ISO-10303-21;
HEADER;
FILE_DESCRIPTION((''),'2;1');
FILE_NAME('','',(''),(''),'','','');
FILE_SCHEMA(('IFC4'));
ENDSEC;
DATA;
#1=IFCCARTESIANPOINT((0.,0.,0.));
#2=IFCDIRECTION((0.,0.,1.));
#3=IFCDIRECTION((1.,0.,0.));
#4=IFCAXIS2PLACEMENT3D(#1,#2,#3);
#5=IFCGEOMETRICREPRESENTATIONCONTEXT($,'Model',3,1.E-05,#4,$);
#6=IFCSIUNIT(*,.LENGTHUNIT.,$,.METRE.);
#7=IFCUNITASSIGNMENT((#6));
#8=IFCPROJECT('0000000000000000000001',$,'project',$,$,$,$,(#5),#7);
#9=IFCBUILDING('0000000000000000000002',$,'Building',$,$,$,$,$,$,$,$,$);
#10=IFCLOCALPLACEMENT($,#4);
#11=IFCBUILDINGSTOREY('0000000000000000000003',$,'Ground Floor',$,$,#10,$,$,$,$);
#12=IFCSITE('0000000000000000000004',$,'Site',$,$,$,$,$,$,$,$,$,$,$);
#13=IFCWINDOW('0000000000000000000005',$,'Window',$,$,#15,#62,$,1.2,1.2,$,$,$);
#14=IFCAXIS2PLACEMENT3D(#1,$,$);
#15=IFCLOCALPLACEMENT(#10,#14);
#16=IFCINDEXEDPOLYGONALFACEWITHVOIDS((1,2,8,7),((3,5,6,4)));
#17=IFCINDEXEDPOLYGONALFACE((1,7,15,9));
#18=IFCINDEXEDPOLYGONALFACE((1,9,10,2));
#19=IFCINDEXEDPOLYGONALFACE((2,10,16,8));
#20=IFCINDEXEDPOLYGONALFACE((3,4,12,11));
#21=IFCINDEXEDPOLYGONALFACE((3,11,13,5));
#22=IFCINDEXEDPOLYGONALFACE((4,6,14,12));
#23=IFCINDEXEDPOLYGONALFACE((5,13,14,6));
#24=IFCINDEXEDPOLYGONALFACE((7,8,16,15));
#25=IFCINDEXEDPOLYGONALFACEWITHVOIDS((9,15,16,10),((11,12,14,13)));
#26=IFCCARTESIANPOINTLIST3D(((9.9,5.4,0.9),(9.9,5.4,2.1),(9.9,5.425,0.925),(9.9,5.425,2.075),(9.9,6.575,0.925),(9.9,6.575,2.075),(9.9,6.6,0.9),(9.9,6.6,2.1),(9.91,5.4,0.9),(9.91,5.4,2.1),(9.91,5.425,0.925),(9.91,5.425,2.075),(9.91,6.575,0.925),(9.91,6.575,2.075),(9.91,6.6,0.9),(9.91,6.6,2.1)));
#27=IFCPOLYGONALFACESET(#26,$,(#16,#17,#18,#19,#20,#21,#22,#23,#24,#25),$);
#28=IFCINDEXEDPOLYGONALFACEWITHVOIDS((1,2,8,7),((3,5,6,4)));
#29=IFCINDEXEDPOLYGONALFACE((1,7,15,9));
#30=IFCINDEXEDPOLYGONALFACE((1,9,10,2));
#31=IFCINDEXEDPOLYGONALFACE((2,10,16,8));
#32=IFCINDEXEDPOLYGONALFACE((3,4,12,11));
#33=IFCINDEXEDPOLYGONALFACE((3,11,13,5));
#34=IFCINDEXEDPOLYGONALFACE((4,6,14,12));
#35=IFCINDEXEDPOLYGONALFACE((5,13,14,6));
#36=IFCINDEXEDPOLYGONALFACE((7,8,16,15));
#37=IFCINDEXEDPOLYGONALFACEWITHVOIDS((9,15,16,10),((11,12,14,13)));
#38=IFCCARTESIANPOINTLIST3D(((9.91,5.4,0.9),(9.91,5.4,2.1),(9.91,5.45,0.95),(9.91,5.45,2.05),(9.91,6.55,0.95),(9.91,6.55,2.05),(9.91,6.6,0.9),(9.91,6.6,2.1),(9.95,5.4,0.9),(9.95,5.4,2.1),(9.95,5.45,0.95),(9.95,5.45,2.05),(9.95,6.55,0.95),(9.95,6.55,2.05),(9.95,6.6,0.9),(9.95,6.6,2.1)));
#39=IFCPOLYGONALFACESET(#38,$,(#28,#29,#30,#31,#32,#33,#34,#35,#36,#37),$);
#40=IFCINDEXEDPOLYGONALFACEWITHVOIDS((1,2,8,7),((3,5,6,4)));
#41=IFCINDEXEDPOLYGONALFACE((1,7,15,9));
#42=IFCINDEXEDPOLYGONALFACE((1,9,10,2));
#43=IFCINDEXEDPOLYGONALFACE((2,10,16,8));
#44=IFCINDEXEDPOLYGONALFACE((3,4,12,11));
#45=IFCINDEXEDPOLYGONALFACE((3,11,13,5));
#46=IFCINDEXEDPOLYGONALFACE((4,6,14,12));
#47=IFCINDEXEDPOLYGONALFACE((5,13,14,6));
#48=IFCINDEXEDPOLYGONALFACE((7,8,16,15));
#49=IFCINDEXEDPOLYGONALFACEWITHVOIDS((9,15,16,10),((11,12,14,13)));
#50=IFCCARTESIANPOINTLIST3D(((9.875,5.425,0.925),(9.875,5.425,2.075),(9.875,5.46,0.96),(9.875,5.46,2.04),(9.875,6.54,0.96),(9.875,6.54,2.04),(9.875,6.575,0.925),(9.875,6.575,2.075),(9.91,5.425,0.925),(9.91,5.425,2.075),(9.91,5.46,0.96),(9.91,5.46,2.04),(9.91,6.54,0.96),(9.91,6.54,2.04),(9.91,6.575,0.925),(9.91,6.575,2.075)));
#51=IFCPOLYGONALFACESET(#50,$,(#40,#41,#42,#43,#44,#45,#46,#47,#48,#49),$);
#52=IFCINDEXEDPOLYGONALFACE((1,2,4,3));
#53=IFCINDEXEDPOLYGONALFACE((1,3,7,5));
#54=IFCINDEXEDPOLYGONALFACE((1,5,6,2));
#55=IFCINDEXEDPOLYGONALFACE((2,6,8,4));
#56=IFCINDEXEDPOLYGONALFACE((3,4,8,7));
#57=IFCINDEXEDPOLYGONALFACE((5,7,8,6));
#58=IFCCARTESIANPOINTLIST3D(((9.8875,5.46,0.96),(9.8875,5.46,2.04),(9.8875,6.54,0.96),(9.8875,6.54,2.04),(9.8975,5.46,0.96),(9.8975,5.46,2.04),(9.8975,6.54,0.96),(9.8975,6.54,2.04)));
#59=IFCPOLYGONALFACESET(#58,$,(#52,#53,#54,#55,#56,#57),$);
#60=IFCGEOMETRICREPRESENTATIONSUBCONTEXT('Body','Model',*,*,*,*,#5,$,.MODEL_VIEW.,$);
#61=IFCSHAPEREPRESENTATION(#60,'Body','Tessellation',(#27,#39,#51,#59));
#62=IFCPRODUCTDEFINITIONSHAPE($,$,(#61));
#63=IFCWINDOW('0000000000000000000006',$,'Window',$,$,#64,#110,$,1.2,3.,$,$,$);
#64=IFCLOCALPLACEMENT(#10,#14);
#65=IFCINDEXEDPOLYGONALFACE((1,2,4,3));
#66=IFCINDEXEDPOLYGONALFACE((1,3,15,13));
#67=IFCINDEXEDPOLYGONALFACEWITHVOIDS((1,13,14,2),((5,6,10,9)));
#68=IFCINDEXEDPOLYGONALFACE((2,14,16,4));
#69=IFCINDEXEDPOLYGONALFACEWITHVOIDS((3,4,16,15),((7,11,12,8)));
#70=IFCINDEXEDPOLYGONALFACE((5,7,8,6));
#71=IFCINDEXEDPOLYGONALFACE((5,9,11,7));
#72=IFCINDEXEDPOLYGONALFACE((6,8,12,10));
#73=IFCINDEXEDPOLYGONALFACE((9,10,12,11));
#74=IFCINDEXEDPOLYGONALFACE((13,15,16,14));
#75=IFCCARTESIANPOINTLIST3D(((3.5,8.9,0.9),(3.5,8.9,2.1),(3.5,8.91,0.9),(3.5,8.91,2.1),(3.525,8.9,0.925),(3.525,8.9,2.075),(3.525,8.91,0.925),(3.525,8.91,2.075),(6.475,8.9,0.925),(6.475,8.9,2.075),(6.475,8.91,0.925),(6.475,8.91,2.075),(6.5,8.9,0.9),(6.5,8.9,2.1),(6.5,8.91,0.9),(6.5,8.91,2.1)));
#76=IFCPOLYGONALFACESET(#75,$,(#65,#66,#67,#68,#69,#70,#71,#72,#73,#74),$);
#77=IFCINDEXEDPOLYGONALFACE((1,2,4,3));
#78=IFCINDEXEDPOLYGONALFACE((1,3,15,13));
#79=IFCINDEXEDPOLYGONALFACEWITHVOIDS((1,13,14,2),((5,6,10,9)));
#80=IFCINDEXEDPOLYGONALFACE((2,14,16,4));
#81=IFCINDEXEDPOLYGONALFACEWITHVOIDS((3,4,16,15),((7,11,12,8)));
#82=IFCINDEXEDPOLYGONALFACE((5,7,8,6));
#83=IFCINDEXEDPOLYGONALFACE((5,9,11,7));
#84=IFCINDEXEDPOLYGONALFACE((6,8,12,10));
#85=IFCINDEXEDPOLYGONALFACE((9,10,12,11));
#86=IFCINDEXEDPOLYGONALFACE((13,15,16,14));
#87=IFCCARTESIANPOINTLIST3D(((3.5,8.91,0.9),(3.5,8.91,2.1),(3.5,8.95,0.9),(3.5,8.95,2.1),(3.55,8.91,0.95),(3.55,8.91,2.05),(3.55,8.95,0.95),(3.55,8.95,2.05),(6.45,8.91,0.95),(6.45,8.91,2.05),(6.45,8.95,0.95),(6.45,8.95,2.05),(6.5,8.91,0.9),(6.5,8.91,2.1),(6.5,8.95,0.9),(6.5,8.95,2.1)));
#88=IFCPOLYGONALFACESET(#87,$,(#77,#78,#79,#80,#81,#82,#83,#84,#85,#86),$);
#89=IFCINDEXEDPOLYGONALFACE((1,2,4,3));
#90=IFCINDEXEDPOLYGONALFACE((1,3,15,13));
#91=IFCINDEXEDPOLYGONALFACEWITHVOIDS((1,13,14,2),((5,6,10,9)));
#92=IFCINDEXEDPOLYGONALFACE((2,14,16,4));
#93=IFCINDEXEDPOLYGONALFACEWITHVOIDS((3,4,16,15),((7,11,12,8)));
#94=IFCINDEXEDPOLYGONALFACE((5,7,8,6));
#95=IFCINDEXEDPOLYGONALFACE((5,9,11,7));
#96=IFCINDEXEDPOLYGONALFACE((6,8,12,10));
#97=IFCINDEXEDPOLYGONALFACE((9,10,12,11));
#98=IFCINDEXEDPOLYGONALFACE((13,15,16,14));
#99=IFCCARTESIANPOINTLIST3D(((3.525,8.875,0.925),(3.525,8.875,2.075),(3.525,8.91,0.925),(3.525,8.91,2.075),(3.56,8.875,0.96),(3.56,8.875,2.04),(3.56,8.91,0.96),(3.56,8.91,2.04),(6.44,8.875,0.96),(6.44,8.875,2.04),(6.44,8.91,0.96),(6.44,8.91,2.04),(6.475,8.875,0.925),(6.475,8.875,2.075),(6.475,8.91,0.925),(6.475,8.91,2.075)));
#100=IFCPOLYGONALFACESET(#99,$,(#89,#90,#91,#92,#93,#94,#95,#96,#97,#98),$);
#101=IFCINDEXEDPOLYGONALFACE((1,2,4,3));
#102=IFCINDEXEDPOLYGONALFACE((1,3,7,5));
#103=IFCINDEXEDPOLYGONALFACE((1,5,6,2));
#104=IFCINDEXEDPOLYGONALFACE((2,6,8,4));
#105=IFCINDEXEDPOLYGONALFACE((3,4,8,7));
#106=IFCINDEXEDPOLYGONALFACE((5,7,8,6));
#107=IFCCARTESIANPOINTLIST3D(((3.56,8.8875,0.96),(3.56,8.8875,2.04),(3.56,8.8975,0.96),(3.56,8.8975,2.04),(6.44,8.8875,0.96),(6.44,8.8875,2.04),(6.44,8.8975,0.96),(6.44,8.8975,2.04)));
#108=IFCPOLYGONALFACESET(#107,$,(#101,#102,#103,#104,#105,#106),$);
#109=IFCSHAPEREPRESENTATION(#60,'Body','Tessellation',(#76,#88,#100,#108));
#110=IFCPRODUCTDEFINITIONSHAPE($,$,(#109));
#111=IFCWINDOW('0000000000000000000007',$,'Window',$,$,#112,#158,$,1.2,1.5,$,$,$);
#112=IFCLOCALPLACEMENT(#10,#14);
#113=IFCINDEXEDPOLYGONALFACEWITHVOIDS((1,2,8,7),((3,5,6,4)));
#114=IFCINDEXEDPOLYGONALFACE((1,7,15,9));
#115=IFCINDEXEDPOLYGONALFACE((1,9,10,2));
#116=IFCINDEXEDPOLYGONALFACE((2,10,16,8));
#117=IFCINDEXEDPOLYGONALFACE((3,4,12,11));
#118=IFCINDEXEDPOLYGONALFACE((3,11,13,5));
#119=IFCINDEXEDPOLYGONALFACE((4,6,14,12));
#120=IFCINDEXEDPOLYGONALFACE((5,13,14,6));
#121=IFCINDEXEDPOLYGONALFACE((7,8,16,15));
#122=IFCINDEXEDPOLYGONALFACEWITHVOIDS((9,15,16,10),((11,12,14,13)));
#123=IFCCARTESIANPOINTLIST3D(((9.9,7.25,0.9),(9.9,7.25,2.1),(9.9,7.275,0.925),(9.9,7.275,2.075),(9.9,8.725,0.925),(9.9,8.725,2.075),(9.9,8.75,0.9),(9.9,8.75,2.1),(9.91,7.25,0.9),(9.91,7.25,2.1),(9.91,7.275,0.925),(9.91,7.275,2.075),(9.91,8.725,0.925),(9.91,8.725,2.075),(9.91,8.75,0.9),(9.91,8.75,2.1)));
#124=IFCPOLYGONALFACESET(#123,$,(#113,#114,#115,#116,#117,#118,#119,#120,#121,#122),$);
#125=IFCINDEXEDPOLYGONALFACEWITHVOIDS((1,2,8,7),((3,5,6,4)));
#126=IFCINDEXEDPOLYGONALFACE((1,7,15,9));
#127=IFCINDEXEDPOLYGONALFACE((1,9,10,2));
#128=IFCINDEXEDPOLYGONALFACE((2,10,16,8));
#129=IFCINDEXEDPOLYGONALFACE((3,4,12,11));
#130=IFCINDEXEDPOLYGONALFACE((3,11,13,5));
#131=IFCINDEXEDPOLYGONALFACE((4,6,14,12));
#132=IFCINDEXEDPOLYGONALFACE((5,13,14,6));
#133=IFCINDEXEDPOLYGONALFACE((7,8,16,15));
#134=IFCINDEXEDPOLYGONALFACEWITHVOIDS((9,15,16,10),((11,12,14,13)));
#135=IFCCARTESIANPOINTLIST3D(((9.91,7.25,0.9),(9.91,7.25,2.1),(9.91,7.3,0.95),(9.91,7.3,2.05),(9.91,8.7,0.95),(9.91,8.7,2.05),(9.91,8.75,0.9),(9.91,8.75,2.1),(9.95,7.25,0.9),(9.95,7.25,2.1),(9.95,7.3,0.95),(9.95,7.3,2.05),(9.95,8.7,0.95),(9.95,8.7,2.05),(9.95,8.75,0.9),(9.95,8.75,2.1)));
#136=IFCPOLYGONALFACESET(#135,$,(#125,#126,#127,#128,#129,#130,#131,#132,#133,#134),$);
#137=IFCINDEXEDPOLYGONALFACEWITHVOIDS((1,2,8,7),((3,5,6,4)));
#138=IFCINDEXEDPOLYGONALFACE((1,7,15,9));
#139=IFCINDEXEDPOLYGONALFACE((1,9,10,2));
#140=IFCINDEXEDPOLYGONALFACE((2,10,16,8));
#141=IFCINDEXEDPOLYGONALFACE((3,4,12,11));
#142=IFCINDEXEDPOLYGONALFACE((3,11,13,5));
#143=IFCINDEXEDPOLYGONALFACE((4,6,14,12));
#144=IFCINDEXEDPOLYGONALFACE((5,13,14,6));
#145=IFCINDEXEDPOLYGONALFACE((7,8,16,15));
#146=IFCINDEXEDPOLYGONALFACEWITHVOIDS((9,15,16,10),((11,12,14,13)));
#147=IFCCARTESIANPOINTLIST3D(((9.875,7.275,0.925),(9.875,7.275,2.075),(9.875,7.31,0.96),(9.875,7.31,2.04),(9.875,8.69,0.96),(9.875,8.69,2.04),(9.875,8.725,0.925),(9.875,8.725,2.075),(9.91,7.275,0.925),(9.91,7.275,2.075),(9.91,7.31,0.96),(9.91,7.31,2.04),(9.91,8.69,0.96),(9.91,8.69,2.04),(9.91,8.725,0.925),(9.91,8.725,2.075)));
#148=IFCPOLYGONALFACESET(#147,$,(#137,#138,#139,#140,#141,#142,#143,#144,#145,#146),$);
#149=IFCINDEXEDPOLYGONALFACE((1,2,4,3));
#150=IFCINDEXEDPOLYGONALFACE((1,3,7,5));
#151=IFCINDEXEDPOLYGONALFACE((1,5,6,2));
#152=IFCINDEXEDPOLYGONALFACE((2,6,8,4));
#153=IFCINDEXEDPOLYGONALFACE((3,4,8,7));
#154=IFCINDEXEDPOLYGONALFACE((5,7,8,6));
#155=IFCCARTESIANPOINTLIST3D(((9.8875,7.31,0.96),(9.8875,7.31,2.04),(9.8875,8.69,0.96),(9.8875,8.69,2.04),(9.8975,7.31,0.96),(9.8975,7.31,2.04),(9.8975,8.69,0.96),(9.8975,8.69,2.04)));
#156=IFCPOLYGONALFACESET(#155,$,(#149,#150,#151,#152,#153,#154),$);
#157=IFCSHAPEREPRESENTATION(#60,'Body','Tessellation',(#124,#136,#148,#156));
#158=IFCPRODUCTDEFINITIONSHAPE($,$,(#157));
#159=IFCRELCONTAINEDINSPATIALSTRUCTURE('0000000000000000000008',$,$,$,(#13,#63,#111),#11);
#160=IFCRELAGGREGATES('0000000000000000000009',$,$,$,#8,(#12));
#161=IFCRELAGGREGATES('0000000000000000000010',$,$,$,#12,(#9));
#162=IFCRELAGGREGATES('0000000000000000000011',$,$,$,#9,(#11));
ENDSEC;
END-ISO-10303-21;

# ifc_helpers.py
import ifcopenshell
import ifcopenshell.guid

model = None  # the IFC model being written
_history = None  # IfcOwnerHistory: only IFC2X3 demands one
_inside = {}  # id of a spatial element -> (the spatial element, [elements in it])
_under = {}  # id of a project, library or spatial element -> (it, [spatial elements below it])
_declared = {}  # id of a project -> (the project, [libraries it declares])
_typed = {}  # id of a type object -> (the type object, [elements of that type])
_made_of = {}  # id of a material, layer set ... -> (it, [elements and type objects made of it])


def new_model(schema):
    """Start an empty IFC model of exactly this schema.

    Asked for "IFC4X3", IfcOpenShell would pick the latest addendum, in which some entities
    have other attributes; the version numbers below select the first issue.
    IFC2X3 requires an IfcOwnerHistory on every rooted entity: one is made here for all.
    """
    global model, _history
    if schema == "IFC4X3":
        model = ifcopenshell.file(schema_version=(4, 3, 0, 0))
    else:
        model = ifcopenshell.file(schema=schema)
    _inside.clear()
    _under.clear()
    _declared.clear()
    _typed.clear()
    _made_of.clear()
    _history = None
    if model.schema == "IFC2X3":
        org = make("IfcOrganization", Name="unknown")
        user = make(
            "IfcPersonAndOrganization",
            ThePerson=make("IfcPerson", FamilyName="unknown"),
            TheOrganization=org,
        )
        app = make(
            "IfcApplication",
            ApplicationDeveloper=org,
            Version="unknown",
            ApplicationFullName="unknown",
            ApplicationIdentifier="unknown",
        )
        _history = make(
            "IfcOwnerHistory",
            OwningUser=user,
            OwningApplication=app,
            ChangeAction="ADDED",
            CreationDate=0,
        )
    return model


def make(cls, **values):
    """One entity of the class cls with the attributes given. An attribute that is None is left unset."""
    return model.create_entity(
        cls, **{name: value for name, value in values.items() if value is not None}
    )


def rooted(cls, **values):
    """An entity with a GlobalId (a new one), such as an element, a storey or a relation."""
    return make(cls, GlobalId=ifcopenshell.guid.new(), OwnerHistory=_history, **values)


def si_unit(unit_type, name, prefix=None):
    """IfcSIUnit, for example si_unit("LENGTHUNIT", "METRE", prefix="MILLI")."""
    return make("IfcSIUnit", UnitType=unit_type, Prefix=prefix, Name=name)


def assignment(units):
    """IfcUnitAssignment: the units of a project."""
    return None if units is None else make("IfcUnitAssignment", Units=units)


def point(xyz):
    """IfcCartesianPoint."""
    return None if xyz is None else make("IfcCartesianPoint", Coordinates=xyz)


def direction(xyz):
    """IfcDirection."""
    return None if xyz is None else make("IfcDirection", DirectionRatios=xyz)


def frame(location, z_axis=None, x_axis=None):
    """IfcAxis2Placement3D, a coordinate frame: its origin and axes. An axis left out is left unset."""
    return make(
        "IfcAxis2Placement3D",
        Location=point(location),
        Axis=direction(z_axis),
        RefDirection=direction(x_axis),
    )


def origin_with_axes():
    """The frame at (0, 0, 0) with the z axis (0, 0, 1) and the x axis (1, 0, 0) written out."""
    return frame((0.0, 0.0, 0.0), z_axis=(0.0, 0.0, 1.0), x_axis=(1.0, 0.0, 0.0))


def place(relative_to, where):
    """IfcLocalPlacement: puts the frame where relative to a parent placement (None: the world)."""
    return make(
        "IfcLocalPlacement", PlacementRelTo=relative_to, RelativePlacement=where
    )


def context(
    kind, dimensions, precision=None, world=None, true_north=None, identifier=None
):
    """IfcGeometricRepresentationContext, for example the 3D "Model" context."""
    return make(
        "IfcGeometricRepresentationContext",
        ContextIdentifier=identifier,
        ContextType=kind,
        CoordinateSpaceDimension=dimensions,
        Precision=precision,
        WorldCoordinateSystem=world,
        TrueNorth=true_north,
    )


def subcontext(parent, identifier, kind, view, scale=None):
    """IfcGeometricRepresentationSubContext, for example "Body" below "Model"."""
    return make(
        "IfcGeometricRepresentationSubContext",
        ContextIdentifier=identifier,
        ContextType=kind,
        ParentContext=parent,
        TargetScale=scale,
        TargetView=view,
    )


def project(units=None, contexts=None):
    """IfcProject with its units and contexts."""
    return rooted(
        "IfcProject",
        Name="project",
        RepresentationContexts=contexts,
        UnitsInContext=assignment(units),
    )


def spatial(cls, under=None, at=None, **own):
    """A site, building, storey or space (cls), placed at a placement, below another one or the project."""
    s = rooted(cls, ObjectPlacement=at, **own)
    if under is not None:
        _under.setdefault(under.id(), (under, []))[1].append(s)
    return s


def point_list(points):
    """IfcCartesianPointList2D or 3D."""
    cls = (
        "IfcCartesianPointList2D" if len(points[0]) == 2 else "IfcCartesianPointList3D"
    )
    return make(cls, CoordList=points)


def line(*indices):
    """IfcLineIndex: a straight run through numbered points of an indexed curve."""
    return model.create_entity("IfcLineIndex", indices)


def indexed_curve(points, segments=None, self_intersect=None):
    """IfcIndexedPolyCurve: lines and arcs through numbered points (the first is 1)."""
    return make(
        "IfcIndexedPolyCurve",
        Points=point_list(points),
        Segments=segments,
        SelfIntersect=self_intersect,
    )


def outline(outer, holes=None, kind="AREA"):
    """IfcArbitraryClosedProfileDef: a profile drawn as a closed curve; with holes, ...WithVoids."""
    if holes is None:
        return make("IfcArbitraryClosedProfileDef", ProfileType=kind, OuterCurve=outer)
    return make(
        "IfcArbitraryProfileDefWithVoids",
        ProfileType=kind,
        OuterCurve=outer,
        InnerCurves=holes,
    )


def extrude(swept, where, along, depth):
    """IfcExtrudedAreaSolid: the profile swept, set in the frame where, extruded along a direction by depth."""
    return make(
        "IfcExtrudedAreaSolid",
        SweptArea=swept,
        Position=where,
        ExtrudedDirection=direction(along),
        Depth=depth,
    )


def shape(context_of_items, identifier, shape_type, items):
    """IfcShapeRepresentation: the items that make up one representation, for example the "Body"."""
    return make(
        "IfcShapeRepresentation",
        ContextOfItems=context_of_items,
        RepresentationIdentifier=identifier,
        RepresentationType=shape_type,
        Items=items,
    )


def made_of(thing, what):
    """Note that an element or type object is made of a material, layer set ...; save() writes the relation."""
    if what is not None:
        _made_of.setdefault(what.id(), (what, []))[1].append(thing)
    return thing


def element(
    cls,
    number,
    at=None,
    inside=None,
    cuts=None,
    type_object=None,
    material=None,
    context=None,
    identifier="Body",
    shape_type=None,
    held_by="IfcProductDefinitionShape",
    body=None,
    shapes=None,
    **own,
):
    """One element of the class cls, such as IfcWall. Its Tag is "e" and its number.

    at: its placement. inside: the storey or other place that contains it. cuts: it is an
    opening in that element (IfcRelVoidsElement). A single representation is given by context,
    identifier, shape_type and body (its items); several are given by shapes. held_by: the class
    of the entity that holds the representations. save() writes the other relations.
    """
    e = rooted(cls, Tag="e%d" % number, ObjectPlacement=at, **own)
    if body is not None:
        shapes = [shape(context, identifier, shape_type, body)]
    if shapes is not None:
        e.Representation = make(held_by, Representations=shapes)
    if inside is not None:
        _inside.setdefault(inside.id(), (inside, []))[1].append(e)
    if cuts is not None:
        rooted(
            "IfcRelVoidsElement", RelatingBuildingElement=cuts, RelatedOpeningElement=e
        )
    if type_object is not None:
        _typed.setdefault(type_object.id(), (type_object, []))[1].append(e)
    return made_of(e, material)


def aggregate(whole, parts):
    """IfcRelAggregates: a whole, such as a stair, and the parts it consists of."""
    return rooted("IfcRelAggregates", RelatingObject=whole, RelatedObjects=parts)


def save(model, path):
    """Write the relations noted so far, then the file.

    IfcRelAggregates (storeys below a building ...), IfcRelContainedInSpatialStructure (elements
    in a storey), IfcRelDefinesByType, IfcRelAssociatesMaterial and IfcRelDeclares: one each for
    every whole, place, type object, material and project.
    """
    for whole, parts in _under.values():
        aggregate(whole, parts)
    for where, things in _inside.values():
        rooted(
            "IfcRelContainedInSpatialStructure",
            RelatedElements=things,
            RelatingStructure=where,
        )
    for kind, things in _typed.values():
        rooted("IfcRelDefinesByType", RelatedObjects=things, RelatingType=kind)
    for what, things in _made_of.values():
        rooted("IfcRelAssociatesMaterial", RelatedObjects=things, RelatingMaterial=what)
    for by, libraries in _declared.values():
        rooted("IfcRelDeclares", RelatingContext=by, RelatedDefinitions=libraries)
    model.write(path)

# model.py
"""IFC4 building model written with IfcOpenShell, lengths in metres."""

from ifc_helpers import new_model, si_unit, frame, origin_with_axes, place, context, subcontext, project, spatial, line, indexed_curve, outline, extrude, element, save


model = new_model("IFC4")

# Units and contexts
model_context = context("Model", 3, precision=1e-05, world=origin_with_axes())
body_context = subcontext(model_context, "Body", "Model", "MODEL_VIEW")
ifc_project = project(units=[si_unit("LENGTHUNIT", "METRE")], contexts=[model_context])

# Site, building, storey
site = spatial("IfcSite", under=ifc_project, Name="Site")
building = spatial("IfcBuilding", under=site, Name="Building")
storey_placement = place(None, origin_with_axes())
storey = spatial("IfcBuildingStorey", under=building, at=storey_placement, Name="Ground Floor")

# Windows
window_1_placement = place(storey_placement, frame((10.0, 5.4, 0.9), z_axis=(0.0, 0.0, 1.0), x_axis=(0.0, 1.0, 0.0)))
element("IfcWindow", 1, at=window_1_placement, inside=storey, Name="Window", OverallHeight=1.2, OverallWidth=1.2, context=body_context, shape_type="SweptSolid", body=[
    extrude(outline(indexed_curve([(0.0, 0.0), (1.2, 0.0), (1.2, 1.2), (0.0, 1.2)], segments=[line(1, 2, 3, 4, 1)]), holes=[indexed_curve([(0.025, 0.025), (1.175, 0.025), (1.175, 1.175), (0.025, 1.175)], segments=[line(1, 2, 3, 4, 1)])]), frame((0.0, 0.09, 0.0), z_axis=(0.0, -1.0, 0.0), x_axis=(1.0, 0.0, 0.0)), (0.0, 0.0, -1.0), 0.01),
    extrude(outline(indexed_curve([(0.0, 0.0), (1.2, 0.0), (1.2, 1.2), (0.0, 1.2)], segments=[line(1, 2, 3, 4, 1)]), holes=[indexed_curve([(0.05, 0.05), (1.15, 0.05), (1.15, 1.15), (0.05, 1.15)], segments=[line(1, 2, 3, 4, 1)])]), frame((0.0, 0.05, 0.0), z_axis=(0.0, -1.0, 0.0), x_axis=(1.0, 0.0, 0.0)), (0.0, 0.0, -1.0), 0.04),
    extrude(outline(indexed_curve([(0.0, 0.0), (1.15, 0.0), (1.15, 1.15), (0.0, 1.15)], segments=[line(1, 2, 3, 4, 1)]), holes=[indexed_curve([(0.035, 0.035), (1.115, 0.035), (1.115, 1.115), (0.035, 1.115)], segments=[line(1, 2, 3, 4, 1)])]), frame((0.025, 0.09, 0.025), z_axis=(0.0, -1.0, 0.0), x_axis=(1.0, 0.0, 0.0)), (0.0, 0.0, -1.0), 0.035),
    extrude(outline(indexed_curve([(0.035, 0.035), (1.115, 0.035), (1.115, 1.115), (0.035, 1.115)], segments=[line(1, 2, 3, 4, 1)])), frame((0.025, 0.1025, 0.025), z_axis=(0.0, -1.0, 0.0), x_axis=(1.0, 0.0, 0.0)), (0.0, 0.0, -1.0), 0.01),
])
window_2_placement = place(storey_placement, frame((6.5, 9.0, 0.9), z_axis=(0.0, 0.0, 1.0), x_axis=(-1.0, 0.0, 0.0)))
element("IfcWindow", 2, at=window_2_placement, inside=storey, Name="Window", OverallHeight=1.2, OverallWidth=3.0, context=body_context, shape_type="SweptSolid", body=[
    extrude(outline(indexed_curve([(0.0, 0.0), (3.0, 0.0), (3.0, 1.2), (0.0, 1.2)], segments=[line(1, 2, 3, 4, 1)]), holes=[indexed_curve([(0.025, 0.025), (2.975, 0.025), (2.975, 1.175), (0.025, 1.175)], segments=[line(1, 2, 3, 4, 1)])]), frame((0.0, 0.09, 0.0), z_axis=(0.0, -1.0, 0.0), x_axis=(1.0, 0.0, 0.0)), (0.0, 0.0, -1.0), 0.01),
    extrude(outline(indexed_curve([(0.0, 0.0), (3.0, 0.0), (3.0, 1.2), (0.0, 1.2)], segments=[line(1, 2, 3, 4, 1)]), holes=[indexed_curve([(0.05, 0.05), (2.95, 0.05), (2.95, 1.15), (0.05, 1.15)], segments=[line(1, 2, 3, 4, 1)])]), frame((0.0, 0.05, 0.0), z_axis=(0.0, -1.0, 0.0), x_axis=(1.0, 0.0, 0.0)), (0.0, 0.0, -1.0), 0.04),
    extrude(outline(indexed_curve([(0.0, 0.0), (2.95, 0.0), (2.95, 1.15), (0.0, 1.15)], segments=[line(1, 2, 3, 4, 1)]), holes=[indexed_curve([(0.035, 0.035), (2.915, 0.035), (2.915, 1.115), (0.035, 1.115)], segments=[line(1, 2, 3, 4, 1)])]), frame((0.025, 0.09, 0.025), z_axis=(0.0, -1.0, 0.0), x_axis=(1.0, 0.0, 0.0)), (0.0, 0.0, -1.0), 0.035),
    extrude(outline(indexed_curve([(0.035, 0.035), (2.915, 0.035), (2.915, 1.115), (0.035, 1.115)], segments=[line(1, 2, 3, 4, 1)])), frame((0.025, 0.1025, 0.025), z_axis=(0.0, -1.0, 0.0), x_axis=(1.0, 0.0, 0.0)), (0.0, 0.0, -1.0), 0.01),
])
window_3_placement = place(storey_placement, frame((10.0, 7.25, 0.9), z_axis=(0.0, 0.0, 1.0), x_axis=(0.0, 1.0, 0.0)))
element("IfcWindow", 3, at=window_3_placement, inside=storey, Name="Window", OverallHeight=1.2, OverallWidth=1.5, context=body_context, shape_type="SweptSolid", body=[
    extrude(outline(indexed_curve([(0.0, 0.0), (1.5, 0.0), (1.5, 1.2), (0.0, 1.2)], segments=[line(1, 2, 3, 4, 1)]), holes=[indexed_curve([(0.025, 0.025), (1.475, 0.025), (1.475, 1.175), (0.025, 1.175)], segments=[line(1, 2, 3, 4, 1)])]), frame((0.0, 0.09, 0.0), z_axis=(0.0, -1.0, 0.0), x_axis=(1.0, 0.0, 0.0)), (0.0, 0.0, -1.0), 0.01),
    extrude(outline(indexed_curve([(0.0, 0.0), (1.5, 0.0), (1.5, 1.2), (0.0, 1.2)], segments=[line(1, 2, 3, 4, 1)]), holes=[indexed_curve([(0.05, 0.05), (1.45, 0.05), (1.45, 1.15), (0.05, 1.15)], segments=[line(1, 2, 3, 4, 1)])]), frame((0.0, 0.05, 0.0), z_axis=(0.0, -1.0, 0.0), x_axis=(1.0, 0.0, 0.0)), (0.0, 0.0, -1.0), 0.04),
    extrude(outline(indexed_curve([(0.0, 0.0), (1.45, 0.0), (1.45, 1.15), (0.0, 1.15)], segments=[line(1, 2, 3, 4, 1)]), holes=[indexed_curve([(0.035, 0.035), (1.415, 0.035), (1.415, 1.115), (0.035, 1.115)], segments=[line(1, 2, 3, 4, 1)])]), frame((0.025, 0.09, 0.025), z_axis=(0.0, -1.0, 0.0), x_axis=(1.0, 0.0, 0.0)), (0.0, 0.0, -1.0), 0.035),
    extrude(outline(indexed_curve([(0.035, 0.035), (1.415, 0.035), (1.415, 1.115), (0.035, 1.115)], segments=[line(1, 2, 3, 4, 1)])), frame((0.025, 0.1025, 0.025), z_axis=(0.0, -1.0, 0.0), x_axis=(1.0, 0.0, 0.0)), (0.0, 0.0, -1.0), 0.01),
])

save(model, "model.ifc")
